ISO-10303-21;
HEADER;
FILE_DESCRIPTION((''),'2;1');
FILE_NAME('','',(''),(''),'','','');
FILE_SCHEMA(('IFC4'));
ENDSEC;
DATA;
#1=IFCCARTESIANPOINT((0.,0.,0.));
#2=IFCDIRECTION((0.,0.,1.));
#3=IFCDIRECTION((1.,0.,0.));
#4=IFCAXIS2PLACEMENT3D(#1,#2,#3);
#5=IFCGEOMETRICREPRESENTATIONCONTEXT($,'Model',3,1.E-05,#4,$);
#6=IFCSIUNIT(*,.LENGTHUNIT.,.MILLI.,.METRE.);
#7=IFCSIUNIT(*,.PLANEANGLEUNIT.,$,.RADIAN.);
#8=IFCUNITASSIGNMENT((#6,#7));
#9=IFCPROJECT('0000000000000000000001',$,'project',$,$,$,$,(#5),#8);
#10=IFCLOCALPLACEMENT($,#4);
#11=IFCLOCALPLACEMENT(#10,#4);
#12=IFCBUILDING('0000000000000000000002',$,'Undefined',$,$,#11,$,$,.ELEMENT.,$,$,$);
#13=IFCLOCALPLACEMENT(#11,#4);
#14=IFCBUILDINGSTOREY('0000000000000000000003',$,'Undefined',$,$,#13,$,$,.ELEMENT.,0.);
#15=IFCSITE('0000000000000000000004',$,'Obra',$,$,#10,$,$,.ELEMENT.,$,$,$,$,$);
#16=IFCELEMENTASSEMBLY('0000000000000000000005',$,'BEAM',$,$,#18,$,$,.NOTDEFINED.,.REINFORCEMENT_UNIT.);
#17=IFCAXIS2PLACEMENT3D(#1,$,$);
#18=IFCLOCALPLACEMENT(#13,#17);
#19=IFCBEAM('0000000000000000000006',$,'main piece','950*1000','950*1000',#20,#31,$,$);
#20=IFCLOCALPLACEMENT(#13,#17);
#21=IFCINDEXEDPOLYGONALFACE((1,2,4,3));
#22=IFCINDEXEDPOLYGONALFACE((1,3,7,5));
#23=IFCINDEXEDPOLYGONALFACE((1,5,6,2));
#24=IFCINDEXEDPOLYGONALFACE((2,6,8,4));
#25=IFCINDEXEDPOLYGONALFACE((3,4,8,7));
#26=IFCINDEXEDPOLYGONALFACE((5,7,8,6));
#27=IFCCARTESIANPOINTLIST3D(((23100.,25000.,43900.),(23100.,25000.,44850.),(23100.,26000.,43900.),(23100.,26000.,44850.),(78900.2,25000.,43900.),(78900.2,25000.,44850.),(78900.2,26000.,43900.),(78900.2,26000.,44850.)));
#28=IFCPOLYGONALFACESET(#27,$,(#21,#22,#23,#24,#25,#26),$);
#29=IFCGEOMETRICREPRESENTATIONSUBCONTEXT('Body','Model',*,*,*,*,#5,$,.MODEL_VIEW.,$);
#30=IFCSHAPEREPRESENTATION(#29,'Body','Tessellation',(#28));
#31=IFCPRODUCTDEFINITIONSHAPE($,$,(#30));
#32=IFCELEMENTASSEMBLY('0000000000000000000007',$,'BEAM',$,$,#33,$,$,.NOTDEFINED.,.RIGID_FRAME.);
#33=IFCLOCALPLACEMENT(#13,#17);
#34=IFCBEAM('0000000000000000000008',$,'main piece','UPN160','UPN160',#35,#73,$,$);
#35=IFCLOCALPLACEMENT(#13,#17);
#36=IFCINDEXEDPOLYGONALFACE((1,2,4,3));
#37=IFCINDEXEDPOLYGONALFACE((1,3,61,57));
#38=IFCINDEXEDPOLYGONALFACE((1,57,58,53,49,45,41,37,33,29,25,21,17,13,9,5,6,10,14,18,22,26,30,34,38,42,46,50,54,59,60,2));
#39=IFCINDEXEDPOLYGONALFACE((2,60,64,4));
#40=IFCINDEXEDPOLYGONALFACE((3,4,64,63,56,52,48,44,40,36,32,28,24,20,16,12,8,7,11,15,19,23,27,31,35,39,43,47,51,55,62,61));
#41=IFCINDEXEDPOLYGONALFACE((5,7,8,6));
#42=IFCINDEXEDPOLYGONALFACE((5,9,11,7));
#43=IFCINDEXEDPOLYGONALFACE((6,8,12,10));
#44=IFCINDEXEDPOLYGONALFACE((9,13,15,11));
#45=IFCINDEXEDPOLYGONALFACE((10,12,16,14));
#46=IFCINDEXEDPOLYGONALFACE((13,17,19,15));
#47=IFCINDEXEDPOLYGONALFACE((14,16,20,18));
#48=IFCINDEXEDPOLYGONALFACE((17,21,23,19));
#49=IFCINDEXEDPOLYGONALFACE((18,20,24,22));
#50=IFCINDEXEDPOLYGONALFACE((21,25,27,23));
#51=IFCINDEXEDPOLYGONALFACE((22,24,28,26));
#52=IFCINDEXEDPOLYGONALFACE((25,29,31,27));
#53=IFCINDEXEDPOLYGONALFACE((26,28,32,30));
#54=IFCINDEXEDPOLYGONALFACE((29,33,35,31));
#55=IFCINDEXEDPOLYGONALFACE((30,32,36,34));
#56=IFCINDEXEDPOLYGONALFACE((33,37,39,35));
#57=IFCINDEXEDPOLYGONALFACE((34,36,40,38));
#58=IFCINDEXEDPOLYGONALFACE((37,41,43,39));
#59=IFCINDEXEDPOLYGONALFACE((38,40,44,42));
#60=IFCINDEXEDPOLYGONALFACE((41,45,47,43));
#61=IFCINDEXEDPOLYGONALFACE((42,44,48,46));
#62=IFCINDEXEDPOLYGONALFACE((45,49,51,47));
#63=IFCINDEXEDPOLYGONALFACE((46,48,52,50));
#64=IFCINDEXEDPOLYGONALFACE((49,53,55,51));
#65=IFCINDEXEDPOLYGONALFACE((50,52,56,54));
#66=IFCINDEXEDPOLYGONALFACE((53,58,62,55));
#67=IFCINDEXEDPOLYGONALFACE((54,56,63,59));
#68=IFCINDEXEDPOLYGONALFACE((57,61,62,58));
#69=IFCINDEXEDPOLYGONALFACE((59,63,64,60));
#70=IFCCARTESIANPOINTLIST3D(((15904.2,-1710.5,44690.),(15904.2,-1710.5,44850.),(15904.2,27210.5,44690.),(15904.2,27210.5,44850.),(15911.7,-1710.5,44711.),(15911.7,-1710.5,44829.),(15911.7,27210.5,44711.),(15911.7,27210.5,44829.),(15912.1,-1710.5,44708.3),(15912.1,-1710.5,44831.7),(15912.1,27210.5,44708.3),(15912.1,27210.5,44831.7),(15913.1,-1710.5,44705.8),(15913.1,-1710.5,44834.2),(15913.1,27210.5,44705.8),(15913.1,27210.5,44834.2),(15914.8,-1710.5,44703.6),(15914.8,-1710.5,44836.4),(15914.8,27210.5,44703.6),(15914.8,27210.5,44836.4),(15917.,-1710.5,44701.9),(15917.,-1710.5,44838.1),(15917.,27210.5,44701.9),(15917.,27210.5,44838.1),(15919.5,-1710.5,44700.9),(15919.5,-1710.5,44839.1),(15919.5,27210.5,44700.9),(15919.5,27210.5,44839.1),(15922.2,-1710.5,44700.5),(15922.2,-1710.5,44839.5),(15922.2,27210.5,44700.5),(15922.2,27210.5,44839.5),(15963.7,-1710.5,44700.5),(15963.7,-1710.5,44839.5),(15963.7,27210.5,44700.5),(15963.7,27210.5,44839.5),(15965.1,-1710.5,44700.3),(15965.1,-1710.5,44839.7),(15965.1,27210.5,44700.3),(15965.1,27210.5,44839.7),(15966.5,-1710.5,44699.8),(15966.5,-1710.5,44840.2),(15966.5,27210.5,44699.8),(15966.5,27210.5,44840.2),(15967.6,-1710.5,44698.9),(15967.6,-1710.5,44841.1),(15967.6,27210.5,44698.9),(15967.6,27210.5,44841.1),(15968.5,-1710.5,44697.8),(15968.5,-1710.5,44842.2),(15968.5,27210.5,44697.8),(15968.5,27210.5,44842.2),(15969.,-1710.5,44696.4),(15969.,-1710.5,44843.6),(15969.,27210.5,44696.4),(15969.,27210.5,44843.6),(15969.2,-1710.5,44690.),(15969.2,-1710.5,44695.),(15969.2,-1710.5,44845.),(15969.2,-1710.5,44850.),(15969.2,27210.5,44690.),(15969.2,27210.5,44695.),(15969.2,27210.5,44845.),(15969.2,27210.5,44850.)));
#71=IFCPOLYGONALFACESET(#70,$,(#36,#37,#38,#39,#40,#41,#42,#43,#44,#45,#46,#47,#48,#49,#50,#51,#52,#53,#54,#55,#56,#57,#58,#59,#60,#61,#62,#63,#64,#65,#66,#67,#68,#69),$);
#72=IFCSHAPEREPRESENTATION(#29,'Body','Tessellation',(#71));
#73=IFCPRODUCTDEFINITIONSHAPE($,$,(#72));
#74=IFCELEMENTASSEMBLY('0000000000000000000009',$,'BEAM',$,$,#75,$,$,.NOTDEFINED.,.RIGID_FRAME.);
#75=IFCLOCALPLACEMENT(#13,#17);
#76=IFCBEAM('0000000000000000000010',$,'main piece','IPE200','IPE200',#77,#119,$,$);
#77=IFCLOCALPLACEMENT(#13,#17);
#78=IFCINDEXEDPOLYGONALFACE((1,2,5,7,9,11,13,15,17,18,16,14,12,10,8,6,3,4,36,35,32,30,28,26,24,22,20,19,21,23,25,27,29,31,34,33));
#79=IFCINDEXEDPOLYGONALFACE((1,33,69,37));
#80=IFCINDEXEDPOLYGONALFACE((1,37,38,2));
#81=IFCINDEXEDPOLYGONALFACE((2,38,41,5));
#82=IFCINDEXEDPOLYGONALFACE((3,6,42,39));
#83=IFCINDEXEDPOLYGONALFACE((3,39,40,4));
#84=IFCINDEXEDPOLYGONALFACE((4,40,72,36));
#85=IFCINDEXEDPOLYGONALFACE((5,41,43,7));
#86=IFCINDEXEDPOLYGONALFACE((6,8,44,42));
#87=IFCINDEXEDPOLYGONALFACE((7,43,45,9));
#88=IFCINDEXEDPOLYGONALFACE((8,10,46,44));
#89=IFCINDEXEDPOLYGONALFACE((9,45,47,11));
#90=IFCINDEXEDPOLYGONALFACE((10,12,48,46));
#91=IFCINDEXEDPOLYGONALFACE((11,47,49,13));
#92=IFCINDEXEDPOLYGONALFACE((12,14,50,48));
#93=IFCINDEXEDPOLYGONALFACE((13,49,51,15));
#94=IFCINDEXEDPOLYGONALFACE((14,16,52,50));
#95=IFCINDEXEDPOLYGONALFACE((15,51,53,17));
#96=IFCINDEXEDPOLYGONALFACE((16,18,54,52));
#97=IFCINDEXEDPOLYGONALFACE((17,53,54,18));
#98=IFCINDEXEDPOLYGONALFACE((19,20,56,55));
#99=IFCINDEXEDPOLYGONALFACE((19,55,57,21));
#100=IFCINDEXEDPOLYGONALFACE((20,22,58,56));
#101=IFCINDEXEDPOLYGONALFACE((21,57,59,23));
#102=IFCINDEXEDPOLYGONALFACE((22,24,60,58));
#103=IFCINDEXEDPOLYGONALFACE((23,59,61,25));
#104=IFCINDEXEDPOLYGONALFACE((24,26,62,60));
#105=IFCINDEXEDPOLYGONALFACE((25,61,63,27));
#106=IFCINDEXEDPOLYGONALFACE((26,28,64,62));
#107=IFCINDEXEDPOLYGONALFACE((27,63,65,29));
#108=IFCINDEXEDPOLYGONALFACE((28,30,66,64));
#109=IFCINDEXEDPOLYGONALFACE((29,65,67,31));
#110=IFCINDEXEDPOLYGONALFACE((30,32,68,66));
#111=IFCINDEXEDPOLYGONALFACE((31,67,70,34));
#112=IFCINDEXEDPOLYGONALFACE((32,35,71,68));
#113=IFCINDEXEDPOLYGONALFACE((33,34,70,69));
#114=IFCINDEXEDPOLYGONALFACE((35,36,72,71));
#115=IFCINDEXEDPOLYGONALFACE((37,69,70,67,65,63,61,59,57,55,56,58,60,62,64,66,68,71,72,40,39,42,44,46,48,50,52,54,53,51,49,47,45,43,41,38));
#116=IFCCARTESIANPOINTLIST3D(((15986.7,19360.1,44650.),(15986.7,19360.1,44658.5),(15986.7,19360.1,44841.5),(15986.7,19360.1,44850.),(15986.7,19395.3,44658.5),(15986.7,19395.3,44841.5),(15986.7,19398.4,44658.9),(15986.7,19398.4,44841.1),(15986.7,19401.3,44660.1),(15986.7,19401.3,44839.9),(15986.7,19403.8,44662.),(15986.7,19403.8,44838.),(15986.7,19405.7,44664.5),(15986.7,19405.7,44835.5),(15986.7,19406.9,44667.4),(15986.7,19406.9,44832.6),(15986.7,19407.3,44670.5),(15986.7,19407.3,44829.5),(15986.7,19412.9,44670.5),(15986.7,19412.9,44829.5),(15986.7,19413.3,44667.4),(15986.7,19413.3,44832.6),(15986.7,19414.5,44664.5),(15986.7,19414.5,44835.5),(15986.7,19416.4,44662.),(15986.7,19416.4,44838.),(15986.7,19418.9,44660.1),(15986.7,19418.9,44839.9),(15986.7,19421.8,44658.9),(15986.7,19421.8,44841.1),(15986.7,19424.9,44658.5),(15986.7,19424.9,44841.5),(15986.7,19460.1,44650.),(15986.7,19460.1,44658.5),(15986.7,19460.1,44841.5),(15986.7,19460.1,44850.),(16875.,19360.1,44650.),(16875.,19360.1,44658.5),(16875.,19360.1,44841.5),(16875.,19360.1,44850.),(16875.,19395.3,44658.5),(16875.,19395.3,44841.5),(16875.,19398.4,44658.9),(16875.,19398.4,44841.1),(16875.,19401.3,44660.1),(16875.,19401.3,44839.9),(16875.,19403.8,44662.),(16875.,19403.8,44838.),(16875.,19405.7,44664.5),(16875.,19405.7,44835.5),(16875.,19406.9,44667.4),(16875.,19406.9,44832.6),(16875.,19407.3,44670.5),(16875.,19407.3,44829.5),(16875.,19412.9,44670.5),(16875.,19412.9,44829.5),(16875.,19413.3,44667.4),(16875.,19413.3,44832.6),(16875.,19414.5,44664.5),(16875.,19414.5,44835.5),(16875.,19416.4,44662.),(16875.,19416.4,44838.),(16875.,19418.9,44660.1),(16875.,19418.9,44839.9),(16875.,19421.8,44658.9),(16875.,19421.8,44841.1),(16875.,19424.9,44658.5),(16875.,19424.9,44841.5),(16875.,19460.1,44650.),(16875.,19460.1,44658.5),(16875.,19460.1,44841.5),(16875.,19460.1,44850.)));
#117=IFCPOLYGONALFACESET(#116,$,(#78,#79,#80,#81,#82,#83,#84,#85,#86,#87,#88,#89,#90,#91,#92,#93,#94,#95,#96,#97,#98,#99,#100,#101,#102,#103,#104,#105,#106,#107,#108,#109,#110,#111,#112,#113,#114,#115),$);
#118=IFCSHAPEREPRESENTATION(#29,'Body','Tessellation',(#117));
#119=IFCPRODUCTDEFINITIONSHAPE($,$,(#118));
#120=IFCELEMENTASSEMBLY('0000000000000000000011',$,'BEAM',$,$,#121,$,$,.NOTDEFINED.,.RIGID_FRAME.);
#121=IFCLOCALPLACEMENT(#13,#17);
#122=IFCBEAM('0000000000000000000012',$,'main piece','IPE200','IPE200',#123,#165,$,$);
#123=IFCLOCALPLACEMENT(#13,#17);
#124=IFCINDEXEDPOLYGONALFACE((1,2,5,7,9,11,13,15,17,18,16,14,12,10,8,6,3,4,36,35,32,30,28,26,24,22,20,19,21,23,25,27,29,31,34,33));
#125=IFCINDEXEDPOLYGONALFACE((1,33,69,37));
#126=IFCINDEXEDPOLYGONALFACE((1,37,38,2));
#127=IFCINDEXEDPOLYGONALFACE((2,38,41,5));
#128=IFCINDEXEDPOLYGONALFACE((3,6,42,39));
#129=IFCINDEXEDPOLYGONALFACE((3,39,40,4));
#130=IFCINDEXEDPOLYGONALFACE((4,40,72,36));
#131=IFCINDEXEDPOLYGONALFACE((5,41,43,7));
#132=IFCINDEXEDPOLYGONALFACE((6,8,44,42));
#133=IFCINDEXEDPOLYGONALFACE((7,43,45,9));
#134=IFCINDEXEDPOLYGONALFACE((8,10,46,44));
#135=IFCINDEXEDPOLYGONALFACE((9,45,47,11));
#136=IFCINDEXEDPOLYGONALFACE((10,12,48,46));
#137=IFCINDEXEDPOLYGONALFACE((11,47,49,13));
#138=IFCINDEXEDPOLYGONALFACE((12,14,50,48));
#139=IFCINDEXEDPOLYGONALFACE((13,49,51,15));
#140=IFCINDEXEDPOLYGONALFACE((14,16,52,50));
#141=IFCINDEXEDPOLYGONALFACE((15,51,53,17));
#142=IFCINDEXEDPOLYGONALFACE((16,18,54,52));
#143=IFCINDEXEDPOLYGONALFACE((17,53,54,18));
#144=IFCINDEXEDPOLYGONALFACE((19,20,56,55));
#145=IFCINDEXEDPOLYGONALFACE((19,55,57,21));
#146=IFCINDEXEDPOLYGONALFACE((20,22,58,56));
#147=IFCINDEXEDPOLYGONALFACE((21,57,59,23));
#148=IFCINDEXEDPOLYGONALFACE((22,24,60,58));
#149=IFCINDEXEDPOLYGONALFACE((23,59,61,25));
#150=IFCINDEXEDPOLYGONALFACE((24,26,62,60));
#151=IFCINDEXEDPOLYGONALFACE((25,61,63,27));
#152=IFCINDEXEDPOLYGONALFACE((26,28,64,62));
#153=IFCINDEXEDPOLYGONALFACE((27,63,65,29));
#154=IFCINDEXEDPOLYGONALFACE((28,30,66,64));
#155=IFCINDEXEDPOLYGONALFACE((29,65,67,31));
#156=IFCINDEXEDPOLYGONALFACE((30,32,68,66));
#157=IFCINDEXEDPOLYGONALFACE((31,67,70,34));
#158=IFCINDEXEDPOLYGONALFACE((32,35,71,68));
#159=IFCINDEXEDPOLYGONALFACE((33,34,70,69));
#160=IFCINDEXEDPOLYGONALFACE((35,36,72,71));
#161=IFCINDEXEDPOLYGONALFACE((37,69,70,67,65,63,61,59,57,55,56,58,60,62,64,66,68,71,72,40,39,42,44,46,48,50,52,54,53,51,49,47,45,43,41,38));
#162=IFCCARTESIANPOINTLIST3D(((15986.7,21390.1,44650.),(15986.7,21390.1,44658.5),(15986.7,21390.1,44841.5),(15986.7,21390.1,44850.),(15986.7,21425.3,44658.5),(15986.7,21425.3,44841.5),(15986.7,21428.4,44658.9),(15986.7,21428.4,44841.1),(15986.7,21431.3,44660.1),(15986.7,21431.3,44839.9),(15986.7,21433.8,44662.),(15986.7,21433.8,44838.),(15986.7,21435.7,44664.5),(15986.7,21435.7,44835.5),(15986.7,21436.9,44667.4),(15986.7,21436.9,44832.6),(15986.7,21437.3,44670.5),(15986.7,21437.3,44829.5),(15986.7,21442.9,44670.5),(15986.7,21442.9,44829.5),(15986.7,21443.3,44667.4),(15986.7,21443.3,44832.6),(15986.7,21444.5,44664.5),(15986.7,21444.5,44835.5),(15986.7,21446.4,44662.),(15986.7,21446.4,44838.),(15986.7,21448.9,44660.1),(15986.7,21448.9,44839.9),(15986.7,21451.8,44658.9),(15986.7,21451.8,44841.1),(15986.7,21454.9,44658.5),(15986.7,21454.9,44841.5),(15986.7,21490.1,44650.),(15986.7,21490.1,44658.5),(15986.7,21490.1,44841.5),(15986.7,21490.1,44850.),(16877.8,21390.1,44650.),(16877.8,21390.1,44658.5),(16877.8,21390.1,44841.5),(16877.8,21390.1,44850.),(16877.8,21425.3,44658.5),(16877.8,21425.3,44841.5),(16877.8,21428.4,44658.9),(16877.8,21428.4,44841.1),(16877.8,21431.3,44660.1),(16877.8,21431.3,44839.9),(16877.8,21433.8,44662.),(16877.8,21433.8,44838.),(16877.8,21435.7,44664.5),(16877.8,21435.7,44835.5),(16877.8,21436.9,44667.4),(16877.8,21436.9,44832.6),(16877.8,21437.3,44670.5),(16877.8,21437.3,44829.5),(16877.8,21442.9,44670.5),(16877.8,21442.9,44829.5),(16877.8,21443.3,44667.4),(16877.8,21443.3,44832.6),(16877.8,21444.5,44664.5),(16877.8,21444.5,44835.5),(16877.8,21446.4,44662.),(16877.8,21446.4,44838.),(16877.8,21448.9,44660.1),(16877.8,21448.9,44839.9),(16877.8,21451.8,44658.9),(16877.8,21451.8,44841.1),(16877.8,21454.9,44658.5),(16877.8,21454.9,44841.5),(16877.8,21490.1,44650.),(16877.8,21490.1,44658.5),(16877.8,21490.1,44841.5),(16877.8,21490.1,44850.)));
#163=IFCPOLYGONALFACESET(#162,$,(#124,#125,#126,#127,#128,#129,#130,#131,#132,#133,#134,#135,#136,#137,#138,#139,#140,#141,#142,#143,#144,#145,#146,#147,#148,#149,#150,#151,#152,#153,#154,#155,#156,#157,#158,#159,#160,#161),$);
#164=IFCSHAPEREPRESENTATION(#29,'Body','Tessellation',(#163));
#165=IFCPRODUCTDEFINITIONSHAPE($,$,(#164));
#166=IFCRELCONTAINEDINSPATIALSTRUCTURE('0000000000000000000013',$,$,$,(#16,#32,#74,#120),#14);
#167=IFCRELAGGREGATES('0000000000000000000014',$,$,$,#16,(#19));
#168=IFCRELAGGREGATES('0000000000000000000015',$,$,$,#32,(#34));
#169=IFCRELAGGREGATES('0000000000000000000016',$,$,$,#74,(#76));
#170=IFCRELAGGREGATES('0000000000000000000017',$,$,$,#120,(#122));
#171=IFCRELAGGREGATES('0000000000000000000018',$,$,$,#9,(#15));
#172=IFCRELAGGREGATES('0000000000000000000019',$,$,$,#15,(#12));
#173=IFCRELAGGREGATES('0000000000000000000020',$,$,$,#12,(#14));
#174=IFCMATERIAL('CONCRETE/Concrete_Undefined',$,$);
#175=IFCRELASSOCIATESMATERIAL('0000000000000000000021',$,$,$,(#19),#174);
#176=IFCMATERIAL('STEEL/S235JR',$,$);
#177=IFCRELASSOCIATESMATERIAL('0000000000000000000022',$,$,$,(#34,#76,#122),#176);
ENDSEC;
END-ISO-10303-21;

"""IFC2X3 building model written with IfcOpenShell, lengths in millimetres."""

from ifc_helpers import new_model, si_unit, frame, origin_with_axes, origin_2d_with_axis, place, context, subcontext, project, spatial, rectangle, i_section, u_section, extrude, material, element, aggregate, save


model = new_model("IFC2X3")

# Units and contexts
model_context = context("Model", 3, precision=1e-05, world=origin_with_axes())
body_context = subcontext(model_context, "Body", "Model", "MODEL_VIEW")
ifc_project = project(units=[si_unit("LENGTHUNIT", "METRE", prefix="MILLI"), si_unit("PLANEANGLEUNIT", "RADIAN")], contexts=[model_context])

# Site, building, storey
site_placement = place(None, origin_with_axes())
site = spatial("IfcSite", under=ifc_project, at=site_placement, Name="Obra", CompositionType="ELEMENT")
building_placement = place(site_placement, origin_with_axes())
building = spatial("IfcBuilding", under=site, at=building_placement, Name="Undefined", CompositionType="ELEMENT")
storey_placement = place(building_placement, origin_with_axes())
storey = spatial("IfcBuildingStorey", under=building, at=storey_placement, Name="Undefined", CompositionType="ELEMENT", Elevation=0.0)

# Shared definitions
ifc_material_1 = material(Name="STEEL/S235JR")

# Element assemblies, beams
ifc_material_2 = material(Name="CONCRETE/Concrete_Undefined")
assembly_1_placement = place(storey_placement, origin_with_axes())
assembly_1 = element("IfcElementAssembly", 1, at=assembly_1_placement, inside=storey, Name="BEAM", AssemblyPlace="NOTDEFINED", PredefinedType="REINFORCEMENT_UNIT")
beam_1_placement = place(assembly_1_placement, frame((23100.0, 25500.0, 44375.0), z_axis=(0.0, 0.0, 1.0), x_axis=(1.0, 0.0, 0.0)))
beam_1 = element("IfcBeam", 2, at=beam_1_placement, material=ifc_material_2, Name="main piece", Description="950*1000", ObjectType="950*1000", context=body_context, shape_type="SweptSolid", body=[
    extrude(rectangle(XDim=1000.0, YDim=950.0, at=origin_2d_with_axis()), frame((55800.2, 0.0, 0.0), z_axis=(-1.0, 0.0, 0.0), x_axis=(0.0, -1.0, 0.0)), (0.0, 0.0, 1.0), 55800.2),
])
aggregate(assembly_1, [beam_1])
assembly_2_placement = place(storey_placement, origin_with_axes())
assembly_2 = element("IfcElementAssembly", 3, at=assembly_2_placement, inside=storey, Name="BEAM", AssemblyPlace="NOTDEFINED", PredefinedType="RIGID_FRAME")
beam_2_placement = place(assembly_2_placement, frame((15936.7, 27210.5, 44770.0), z_axis=(0.0, 0.0, -1.0), x_axis=(0.0, -1.0, 0.0)))
beam_2 = element("IfcBeam", 4, at=beam_2_placement, material=ifc_material_1, Name="main piece", Description="UPN160", ObjectType="UPN160", context=body_context, shape_type="SweptSolid", body=[
    extrude(u_section(Depth=160.0, FlangeWidth=65.0, WebThickness=7.5, FlangeThickness=10.5, FilletRadius=10.5, EdgeRadius=5.5, at=origin_2d_with_axis()), frame((28921.0, 0.0, 0.0), z_axis=(-1.0, 0.0, 0.0), x_axis=(0.0, -1.0, 0.0)), (0.0, 0.0, 1.0), 28921.0),
])
aggregate(assembly_2, [beam_2])
assembly_3_placement = place(storey_placement, origin_with_axes())
assembly_3 = element("IfcElementAssembly", 5, at=assembly_3_placement, inside=storey, Name="BEAM", AssemblyPlace="NOTDEFINED", PredefinedType="RIGID_FRAME")
beam_3_placement = place(assembly_3_placement, frame((15986.7, 19410.1, 44750.0), z_axis=(0.0, 0.0, 1.0), x_axis=(1.0, 0.0, 0.0)))
beam_3 = element("IfcBeam", 6, at=beam_3_placement, material=ifc_material_1, Name="main piece", Description="IPE200", ObjectType="IPE200", context=body_context, shape_type="SweptSolid", body=[
    extrude(i_section(OverallWidth=100.0, OverallDepth=200.0, WebThickness=5.6, FlangeThickness=8.5, FilletRadius=12.0, at=origin_2d_with_axis()), frame((888.3, 0.0, 0.0), z_axis=(-1.0, 0.0, 0.0), x_axis=(0.0, -1.0, 0.0)), (0.0, 0.0, 1.0), 888.3),
])
aggregate(assembly_3, [beam_3])
assembly_4_placement = place(storey_placement, origin_with_axes())
assembly_4 = element("IfcElementAssembly", 7, at=assembly_4_placement, inside=storey, Name="BEAM", AssemblyPlace="NOTDEFINED", PredefinedType="RIGID_FRAME")
beam_4_placement = place(assembly_4_placement, frame((16877.8, 21440.1, 44750.0), z_axis=(0.0, 0.0, 1.0), x_axis=(-1.0, -0.000037, 0.0)))
beam_4 = element("IfcBeam", 8, at=beam_4_placement, material=ifc_material_1, Name="main piece", Description="IPE200", ObjectType="IPE200", context=body_context, shape_type="SweptSolid", body=[
    extrude(i_section(OverallWidth=100.0, OverallDepth=200.0, WebThickness=5.6, FlangeThickness=8.5, FilletRadius=12.0, at=origin_2d_with_axis()), frame((891.1, 0.0, 0.0), z_axis=(-1.0, 0.0, 0.0), x_axis=(0.0, -1.0, 0.0)), (0.0, 0.0, 1.0), 891.1),
])
aggregate(assembly_4, [beam_4])

save(model, "model.ifc")
